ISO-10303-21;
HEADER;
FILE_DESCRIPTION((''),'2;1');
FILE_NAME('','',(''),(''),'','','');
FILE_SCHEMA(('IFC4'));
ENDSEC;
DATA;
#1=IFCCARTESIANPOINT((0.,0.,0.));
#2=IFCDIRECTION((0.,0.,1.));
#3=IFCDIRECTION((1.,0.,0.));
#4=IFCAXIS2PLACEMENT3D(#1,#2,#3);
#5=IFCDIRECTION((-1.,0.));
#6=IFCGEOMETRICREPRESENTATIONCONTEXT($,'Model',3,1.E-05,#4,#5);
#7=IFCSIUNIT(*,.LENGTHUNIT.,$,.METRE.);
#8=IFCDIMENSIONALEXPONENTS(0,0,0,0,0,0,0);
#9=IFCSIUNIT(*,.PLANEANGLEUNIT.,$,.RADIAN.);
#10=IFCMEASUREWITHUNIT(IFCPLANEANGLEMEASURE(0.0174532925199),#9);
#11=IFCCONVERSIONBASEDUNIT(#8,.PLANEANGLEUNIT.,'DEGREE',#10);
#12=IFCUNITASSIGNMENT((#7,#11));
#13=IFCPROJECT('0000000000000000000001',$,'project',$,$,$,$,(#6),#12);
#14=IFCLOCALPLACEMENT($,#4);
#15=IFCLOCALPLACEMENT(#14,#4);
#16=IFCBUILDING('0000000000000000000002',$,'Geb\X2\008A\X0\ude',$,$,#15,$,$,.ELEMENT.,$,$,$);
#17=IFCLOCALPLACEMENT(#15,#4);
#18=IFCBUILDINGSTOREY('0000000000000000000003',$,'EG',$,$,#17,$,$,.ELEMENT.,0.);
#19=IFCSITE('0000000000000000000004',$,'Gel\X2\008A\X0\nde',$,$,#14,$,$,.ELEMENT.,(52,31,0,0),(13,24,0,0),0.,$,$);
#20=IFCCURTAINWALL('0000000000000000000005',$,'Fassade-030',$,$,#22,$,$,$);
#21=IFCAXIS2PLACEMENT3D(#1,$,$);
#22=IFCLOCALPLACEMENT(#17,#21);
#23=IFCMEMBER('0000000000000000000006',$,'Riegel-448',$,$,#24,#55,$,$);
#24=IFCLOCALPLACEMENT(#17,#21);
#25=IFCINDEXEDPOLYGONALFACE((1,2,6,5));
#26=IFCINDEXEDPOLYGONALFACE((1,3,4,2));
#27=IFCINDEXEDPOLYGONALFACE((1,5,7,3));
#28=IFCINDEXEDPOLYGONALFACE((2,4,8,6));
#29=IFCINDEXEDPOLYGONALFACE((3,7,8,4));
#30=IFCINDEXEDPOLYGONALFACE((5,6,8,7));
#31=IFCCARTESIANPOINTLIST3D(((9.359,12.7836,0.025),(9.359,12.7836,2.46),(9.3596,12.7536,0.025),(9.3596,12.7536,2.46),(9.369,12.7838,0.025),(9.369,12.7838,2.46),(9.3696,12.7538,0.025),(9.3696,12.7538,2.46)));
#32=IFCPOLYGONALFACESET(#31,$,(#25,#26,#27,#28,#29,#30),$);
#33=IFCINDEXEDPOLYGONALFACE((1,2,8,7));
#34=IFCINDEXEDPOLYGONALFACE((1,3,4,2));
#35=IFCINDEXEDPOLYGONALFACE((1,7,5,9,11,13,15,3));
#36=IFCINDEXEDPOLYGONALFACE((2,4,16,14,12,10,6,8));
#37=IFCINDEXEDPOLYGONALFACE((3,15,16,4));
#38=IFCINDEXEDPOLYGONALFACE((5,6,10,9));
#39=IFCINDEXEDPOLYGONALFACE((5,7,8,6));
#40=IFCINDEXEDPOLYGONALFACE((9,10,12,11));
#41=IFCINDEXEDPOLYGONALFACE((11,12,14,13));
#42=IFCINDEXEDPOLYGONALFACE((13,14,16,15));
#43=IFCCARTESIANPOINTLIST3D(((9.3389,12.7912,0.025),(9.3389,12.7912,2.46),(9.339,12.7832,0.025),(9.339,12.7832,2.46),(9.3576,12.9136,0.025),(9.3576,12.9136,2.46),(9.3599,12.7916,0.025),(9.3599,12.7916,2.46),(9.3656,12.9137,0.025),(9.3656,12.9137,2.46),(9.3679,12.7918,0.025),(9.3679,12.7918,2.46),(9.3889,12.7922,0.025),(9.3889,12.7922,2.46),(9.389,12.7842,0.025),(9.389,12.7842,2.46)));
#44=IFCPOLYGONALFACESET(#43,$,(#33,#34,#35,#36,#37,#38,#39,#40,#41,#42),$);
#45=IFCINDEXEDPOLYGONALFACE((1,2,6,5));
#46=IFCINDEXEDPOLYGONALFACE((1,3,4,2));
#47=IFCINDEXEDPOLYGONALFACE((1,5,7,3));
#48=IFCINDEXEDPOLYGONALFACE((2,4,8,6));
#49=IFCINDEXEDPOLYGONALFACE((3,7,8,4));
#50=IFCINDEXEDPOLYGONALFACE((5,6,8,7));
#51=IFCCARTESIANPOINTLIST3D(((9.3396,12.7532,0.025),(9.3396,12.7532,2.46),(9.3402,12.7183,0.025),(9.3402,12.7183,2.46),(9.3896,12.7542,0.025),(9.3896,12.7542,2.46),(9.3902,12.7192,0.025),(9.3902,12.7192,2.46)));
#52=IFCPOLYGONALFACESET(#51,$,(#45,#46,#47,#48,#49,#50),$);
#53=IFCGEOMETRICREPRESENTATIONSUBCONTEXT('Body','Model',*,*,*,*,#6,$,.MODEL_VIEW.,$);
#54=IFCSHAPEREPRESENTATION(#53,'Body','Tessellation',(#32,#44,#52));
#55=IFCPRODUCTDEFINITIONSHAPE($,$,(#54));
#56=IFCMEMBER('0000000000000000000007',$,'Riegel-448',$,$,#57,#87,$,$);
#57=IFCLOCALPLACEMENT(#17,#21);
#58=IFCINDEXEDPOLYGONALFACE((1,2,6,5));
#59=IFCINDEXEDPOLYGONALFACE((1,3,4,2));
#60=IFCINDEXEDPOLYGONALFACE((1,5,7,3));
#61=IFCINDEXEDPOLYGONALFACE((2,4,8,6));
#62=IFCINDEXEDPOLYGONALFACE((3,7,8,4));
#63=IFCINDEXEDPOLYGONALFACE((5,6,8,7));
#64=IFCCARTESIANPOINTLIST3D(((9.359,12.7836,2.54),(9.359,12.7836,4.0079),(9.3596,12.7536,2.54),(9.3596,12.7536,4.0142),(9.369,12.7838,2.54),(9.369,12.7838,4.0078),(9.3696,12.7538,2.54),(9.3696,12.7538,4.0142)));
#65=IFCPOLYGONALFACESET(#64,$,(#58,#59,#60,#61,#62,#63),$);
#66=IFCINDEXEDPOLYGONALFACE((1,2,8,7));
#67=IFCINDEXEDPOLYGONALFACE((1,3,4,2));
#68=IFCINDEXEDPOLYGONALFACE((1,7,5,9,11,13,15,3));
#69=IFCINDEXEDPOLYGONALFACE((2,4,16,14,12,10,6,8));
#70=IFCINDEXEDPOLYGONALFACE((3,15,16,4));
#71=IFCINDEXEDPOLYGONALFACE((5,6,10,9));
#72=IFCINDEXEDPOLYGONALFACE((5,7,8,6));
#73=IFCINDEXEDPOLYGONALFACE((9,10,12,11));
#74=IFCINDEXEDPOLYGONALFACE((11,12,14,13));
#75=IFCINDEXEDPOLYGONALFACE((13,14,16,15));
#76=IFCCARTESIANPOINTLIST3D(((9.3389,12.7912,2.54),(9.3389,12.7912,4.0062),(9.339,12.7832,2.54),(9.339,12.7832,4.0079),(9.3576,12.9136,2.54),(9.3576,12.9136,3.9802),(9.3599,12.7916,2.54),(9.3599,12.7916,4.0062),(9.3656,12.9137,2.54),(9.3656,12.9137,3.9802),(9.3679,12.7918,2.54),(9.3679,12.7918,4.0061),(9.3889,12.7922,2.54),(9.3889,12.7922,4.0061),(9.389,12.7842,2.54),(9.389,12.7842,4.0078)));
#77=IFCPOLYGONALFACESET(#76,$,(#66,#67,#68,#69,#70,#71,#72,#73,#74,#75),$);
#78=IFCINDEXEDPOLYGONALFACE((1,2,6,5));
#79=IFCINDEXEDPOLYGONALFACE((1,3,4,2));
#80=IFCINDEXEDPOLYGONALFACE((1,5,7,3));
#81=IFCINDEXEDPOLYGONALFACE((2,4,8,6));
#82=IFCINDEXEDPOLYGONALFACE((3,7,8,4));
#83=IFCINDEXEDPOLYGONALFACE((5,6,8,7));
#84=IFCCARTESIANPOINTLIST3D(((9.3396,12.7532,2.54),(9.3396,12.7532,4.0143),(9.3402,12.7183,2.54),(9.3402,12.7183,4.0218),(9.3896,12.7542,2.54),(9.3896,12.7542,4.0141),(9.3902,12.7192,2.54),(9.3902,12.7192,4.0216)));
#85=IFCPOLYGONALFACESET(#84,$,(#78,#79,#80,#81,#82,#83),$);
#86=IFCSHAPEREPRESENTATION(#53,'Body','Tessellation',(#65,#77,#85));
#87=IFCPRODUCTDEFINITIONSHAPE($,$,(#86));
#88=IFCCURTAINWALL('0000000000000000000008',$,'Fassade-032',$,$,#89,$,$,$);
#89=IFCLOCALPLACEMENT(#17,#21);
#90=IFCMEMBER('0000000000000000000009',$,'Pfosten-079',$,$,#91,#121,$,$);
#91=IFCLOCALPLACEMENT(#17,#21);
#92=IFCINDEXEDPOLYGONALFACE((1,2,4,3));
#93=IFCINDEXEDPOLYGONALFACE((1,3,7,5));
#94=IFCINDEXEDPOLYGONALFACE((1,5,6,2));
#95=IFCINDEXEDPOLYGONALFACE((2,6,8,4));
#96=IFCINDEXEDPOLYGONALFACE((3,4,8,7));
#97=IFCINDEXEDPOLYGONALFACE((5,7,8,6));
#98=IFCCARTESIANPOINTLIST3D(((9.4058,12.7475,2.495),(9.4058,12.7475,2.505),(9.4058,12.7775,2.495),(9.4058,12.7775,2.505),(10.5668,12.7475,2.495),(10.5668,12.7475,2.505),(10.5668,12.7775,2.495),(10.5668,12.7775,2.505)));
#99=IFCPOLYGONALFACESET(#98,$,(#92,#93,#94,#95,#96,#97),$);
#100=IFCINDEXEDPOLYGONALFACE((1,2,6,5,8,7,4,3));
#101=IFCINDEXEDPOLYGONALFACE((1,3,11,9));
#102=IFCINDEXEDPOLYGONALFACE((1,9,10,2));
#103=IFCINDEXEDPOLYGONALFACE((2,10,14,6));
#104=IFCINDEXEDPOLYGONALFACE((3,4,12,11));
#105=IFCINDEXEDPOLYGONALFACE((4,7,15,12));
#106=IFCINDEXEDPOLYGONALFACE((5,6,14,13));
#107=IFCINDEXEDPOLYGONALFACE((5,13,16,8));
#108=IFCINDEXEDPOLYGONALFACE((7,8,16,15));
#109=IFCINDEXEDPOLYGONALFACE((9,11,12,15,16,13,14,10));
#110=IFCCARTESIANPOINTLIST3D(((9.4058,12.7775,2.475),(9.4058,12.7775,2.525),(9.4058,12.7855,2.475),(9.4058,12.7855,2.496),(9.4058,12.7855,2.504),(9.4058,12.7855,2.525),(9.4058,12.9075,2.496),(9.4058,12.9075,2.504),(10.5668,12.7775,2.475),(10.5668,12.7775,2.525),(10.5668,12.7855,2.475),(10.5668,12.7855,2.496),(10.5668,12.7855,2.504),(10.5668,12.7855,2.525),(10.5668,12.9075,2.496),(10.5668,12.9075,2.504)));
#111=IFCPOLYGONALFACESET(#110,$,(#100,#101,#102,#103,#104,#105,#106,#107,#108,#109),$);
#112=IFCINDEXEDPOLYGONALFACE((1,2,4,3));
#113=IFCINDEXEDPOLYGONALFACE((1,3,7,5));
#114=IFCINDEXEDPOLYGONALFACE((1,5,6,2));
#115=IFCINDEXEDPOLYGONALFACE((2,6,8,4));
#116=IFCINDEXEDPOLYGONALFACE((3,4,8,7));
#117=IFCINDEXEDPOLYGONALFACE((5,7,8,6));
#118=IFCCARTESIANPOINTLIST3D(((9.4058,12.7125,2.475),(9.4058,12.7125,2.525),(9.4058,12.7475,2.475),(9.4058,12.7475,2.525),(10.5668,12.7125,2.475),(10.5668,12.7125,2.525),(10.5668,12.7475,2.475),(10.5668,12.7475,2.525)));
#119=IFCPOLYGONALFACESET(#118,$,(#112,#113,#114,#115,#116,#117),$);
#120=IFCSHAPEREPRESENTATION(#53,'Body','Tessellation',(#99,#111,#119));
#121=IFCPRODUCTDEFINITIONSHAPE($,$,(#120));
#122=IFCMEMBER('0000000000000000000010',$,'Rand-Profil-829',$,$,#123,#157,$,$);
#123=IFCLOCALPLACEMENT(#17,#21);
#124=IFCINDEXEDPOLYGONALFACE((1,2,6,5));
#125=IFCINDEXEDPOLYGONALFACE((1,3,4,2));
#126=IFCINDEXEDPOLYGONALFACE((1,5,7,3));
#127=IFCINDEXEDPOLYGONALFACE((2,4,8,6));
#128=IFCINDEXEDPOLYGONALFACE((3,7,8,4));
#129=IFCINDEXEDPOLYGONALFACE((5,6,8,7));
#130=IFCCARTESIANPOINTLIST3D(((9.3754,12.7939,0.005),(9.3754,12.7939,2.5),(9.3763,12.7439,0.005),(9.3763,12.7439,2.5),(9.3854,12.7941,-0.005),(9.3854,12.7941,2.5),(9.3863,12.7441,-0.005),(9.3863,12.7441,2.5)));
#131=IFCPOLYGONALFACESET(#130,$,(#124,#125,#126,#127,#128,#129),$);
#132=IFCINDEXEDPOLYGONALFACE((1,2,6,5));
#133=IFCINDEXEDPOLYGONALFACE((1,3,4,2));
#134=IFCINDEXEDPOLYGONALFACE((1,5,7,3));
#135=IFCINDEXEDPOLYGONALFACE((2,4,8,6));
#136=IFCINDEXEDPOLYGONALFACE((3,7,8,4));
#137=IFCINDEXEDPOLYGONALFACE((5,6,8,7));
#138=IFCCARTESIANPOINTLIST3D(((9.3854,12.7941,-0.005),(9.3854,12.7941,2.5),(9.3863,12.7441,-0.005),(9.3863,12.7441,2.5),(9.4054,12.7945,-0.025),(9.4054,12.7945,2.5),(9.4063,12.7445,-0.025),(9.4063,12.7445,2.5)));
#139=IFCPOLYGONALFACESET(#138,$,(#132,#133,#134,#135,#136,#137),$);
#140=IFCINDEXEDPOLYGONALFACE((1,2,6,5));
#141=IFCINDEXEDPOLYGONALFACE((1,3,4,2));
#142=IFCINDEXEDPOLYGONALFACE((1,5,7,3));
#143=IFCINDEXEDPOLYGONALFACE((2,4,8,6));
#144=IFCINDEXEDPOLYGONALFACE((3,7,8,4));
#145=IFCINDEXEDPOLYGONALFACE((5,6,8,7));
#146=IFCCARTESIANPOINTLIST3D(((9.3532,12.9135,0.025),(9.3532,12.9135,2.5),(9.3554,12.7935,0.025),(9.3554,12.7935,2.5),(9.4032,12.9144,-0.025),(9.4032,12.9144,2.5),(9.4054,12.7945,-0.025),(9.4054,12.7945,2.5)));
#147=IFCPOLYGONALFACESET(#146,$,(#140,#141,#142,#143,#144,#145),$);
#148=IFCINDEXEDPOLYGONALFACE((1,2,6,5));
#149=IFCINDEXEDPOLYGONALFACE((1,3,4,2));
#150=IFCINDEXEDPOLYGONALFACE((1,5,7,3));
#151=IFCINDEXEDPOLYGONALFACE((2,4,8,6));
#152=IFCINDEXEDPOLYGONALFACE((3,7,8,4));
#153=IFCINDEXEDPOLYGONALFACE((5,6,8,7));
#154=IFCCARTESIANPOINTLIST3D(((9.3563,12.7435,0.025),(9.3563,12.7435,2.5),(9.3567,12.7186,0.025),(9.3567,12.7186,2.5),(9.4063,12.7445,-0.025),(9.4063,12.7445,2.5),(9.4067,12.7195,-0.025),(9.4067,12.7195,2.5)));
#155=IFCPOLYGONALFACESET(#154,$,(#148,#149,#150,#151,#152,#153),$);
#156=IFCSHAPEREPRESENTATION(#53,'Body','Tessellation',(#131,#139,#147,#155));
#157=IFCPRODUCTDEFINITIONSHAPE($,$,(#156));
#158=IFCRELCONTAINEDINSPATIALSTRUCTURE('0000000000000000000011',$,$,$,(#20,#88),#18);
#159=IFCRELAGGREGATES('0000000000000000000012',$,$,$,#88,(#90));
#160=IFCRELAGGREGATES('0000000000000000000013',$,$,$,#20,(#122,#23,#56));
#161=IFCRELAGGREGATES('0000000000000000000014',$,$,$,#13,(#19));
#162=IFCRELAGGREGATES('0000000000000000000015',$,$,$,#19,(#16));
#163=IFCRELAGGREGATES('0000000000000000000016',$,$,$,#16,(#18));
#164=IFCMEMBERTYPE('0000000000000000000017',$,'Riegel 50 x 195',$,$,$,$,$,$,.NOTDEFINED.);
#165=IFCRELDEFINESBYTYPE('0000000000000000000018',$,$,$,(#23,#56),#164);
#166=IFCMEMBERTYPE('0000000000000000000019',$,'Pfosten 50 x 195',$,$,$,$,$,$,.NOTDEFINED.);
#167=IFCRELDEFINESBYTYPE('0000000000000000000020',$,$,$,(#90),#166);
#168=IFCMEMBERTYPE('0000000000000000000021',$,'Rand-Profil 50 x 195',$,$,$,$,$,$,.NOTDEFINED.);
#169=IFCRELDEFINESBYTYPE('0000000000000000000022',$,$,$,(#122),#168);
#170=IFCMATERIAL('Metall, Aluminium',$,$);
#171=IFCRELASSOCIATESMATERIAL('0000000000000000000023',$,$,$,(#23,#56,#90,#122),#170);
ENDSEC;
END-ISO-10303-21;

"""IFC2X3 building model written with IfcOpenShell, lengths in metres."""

from ifc_helpers import new_model, entity, si_unit, converted_unit, direction, frame, origin_with_axes, place, context, subcontext, project, spatial, polyline, outline, extrude, clip, halfspace, material, type_object, element, aggregate, save


model = new_model("IFC2X3")

# Units and contexts
model_context = context("Model", 3, precision=1e-05, world=origin_with_axes(), true_north=direction((-1.0, 0.0)))
body_context = subcontext(model_context, "Body", "Model", "MODEL_VIEW")
ifc_project = project(units=[si_unit("LENGTHUNIT", "METRE"), converted_unit("PLANEANGLEUNIT", "DEGREE", entity("IfcPlaneAngleMeasure", 0.0174532925199), si_unit("PLANEANGLEUNIT", "RADIAN"), dimensions=[0, 0, 0, 0, 0, 0, 0])], contexts=[model_context])

# Site, building, storey
site_placement = place(None, origin_with_axes())
site = spatial("IfcSite", under=ifc_project, at=site_placement, Name="Gel\u008ande", CompositionType="ELEMENT", RefLatitude=(52, 31, 0, 0), RefLongitude=(13, 24, 0, 0), RefElevation=0.0)
building_placement = place(site_placement, origin_with_axes())
building = spatial("IfcBuilding", under=site, at=building_placement, Name="Geb\u008aude", CompositionType="ELEMENT")
storey_placement = place(building_placement, origin_with_axes())
storey = spatial("IfcBuildingStorey", under=building, at=storey_placement, Name="EG", CompositionType="ELEMENT", Elevation=0.0)

# Curtain wall, members
curtain_wall_1_placement = place(storey_placement, frame((8.7714, 12.7579, 0.0), z_axis=(0.0, 0.0, 1.0), x_axis=(1.0, 0.0, 0.0)))
curtain_wall_1 = element("IfcCurtainWall", 1, at=curtain_wall_1_placement, inside=storey, Name="Fassade-030")
ifc_material_1 = material(Name="Metall, Aluminium")
member_type_1 = type_object("IfcMemberType", Name="Riegel 50 x 195", PredefinedType="NOTDEFINED")
member_1_placement = place(curtain_wall_1_placement, frame((0.5929, 0.0108, 0.0), z_axis=(0.0, 0.0, 1.0), x_axis=(-0.999835, -0.018178, 0.0)))
member_1 = element("IfcMember", 2, at=member_1_placement, type_object=member_type_1, material=ifc_material_1, Name="Riegel-448", context=body_context, shape_type="SweptSolid", body=[
    extrude(outline(polyline([(-0.0053, 0.0149), (-0.0047, -0.0151), (0.0053, -0.0149), (0.0047, 0.0151), (-0.0053, 0.0149)])), frame((0.0, 0.0, 0.025), z_axis=(0.0, 0.0, 1.0), x_axis=(-0.999835, 0.018178, 0.0)), (0.0, 0.0, 1.0), 2.435),
    extrude(outline(polyline([(-0.0066, 0.1449), (-0.0044, 0.0229), (-0.0254, 0.0225), (-0.0253, 0.0145), (0.0247, 0.0155), (0.0246, 0.0235), (0.0036, 0.0231), (0.0014, 0.145), (-0.0066, 0.1449)])), frame((0.0, 0.0, 0.025), z_axis=(0.0, 0.0, 1.0), x_axis=(-0.999835, 0.018178, 0.0)), (0.0, 0.0, 1.0), 2.435),
    extrude(outline(polyline([(0.0259, -0.0495), (0.0253, -0.0145), (-0.0247, -0.0155), (-0.0241, -0.0504), (0.0259, -0.0495)])), frame((0.0, 0.0, 0.025), z_axis=(0.0, 0.0, 1.0), x_axis=(-0.999835, 0.018178, 0.0)), (0.0, 0.0, 1.0), 2.435),
])
member_2_placement = place(curtain_wall_1_placement, frame((0.5929, 0.0108, 2.5), z_axis=(0.0, 0.0, 1.0), x_axis=(-0.999835, -0.018178, 0.0)))
member_2 = element("IfcMember", 3, at=member_2_placement, type_object=member_type_1, material=ifc_material_1, Name="Riegel-448", context=body_context, shape_type="Clipping", body=[
    clip(extrude(outline(polyline([(0.0053, -0.0149), (0.0047, 0.0151), (-0.0053, 0.0149), (-0.0047, -0.0151), (0.0053, -0.0149)])), frame((0.0, 0.0, 0.04), z_axis=(0.0, 0.0, 1.0), x_axis=(-0.999835, 0.018178, 0.0)), (0.0, 0.0, 1.0), 1.4742), halfspace(frame((-0.0056, -0.3072, 1.4457), z_axis=(0.003779, 0.207877, -0.978148), x_axis=(0.0, -0.978155, -0.207879)), True)),
    clip(extrude(outline(polyline([(0.0247, 0.0155), (0.0246, 0.0235), (0.0036, 0.0231), (0.0014, 0.145), (-0.0066, 0.1449), (-0.0044, 0.0229), (-0.0254, 0.0225), (-0.0253, 0.0145), (0.0247, 0.0155)])), frame((0.0, 0.0, 0.04), z_axis=(0.0, 0.0, 1.0), x_axis=(-0.999835, 0.018178, 0.0)), (0.0, 0.0, 1.0), 1.4679), halfspace(frame((-0.0056, -0.3072, 1.4457), z_axis=(0.003779, 0.207877, -0.978148), x_axis=(0.0, -0.978155, -0.207879)), True)),
    clip(extrude(outline(polyline([(0.0259, -0.0495), (0.0253, -0.0145), (-0.0247, -0.0155), (-0.0241, -0.0504), (0.0259, -0.0495)])), frame((0.0, 0.0, 0.04), z_axis=(0.0, 0.0, 1.0), x_axis=(-0.999835, 0.018178, 0.0)), (0.0, 0.0, 1.0), 1.4818), halfspace(frame((-0.0056, -0.3072, 1.4457), z_axis=(0.003779, 0.207877, -0.978148), x_axis=(0.0, -0.978155, -0.207879)), True)),
])

# Curtain wall, member
curtain_wall_2_placement = place(storey_placement, frame((9.9738, 12.7625, 0.0), z_axis=(0.0, 0.0, 1.0), x_axis=(1.0, 0.0, 0.0)))
curtain_wall_2 = element("IfcCurtainWall", 4, at=curtain_wall_2_placement, inside=storey, Name="Fassade-032")
member_type_2 = type_object("IfcMemberType", Name="Pfosten 50 x 195", PredefinedType="NOTDEFINED")
member_3_placement = place(curtain_wall_2_placement, frame((-0.593, 0.0, 2.5), z_axis=(1.0, 0.0, 0.0), x_axis=(0.0, 0.0, 1.0)))
member_3 = element("IfcMember", 5, at=member_3_placement, type_object=member_type_2, material=ifc_material_1, Name="Pfosten-079", context=body_context, shape_type="SweptSolid", body=[
    extrude(outline(polyline([(-0.015, -0.005), (0.015, -0.005), (0.015, 0.005), (-0.015, 0.005), (-0.015, -0.005)])), frame((0.0, 0.0, 0.025), z_axis=(0.0, 0.0, 1.0), x_axis=(0.0, 1.0, 0.0)), (0.0, 0.0, 1.0), 1.161),
    extrude(outline(polyline([(-0.145, -0.004), (-0.023, -0.004), (-0.023, -0.025), (-0.015, -0.025), (-0.015, 0.025), (-0.023, 0.025), (-0.023, 0.004), (-0.145, 0.004), (-0.145, -0.004)])), frame((0.0, 0.0, 0.025), z_axis=(0.0, 0.0, 1.0), x_axis=(0.0, 1.0, 0.0)), (0.0, 0.0, 1.0), 1.161),
    extrude(outline(polyline([(0.05, 0.025), (0.015, 0.025), (0.015, -0.025), (0.05, -0.025), (0.05, 0.025)])), frame((0.0, 0.0, 0.025), z_axis=(0.0, 0.0, 1.0), x_axis=(0.0, 1.0, 0.0)), (0.0, 0.0, 1.0), 1.161),
])

# Member
member_type_3 = type_object("IfcMemberType", Name="Rand-Profil 50 x 195", PredefinedType="NOTDEFINED")
member_4_placement = place(curtain_wall_1_placement, frame((0.6094, 0.0111, 0.0), z_axis=(0.0, 0.0, 1.0), x_axis=(-0.999835, -0.018178, 0.0)))
member_4 = element("IfcMember", 6, at=member_4_placement, type_object=member_type_3, material=ifc_material_1, Name="Rand-Profil-829", context=body_context, shape_type="Clipping", body=[
    clip(extrude(outline(polyline([(-0.0055, 0.0249), (-0.0045, -0.0251), (0.0055, -0.0249), (0.0045, 0.0251), (-0.0055, 0.0249)])), frame((0.0, 0.0, -0.005), z_axis=(0.0, 0.0, 1.0), x_axis=(-0.999835, 0.018178, 0.0)), (0.0, 0.0, 1.0), 2.505), halfspace(frame((0.0, 0.0, 0.0), z_axis=(-0.707107, 0.0, 0.707107), x_axis=(-0.707107, 0.0, -0.707107)), True)),
    clip(extrude(outline(polyline([(0.0045, 0.0251), (0.0055, -0.0249), (0.0255, -0.0245), (0.0245, 0.0255), (0.0045, 0.0251)])), frame((0.0, 0.0, -0.025), z_axis=(0.0, 0.0, 1.0), x_axis=(-0.999835, 0.018178, 0.0)), (0.0, 0.0, 1.0), 2.525), halfspace(frame((0.0, 0.0, 0.0), z_axis=(-0.707107, 0.0, 0.707107), x_axis=(-0.707107, 0.0, -0.707107)), True)),
    clip(extrude(outline(polyline([(-0.0276, 0.1445), (-0.0255, 0.0245), (0.0245, 0.0255), (0.0224, 0.1454), (-0.0276, 0.1445)])), frame((0.0, 0.0, -0.025), z_axis=(0.0, 0.0, 1.0), x_axis=(-0.999835, 0.018178, 0.0)), (0.0, 0.0, 1.0), 2.525), halfspace(frame((0.0, 0.0, 0.0), z_axis=(-0.707107, 0.0, 0.707107), x_axis=(-0.707107, 0.0, -0.707107)), True)),
    clip(extrude(outline(polyline([(0.0259, -0.0495), (0.0255, -0.0245), (-0.0245, -0.0255), (-0.0241, -0.0504), (0.0259, -0.0495)])), frame((0.0, 0.0, -0.025), z_axis=(0.0, 0.0, 1.0), x_axis=(-0.999835, 0.018178, 0.0)), (0.0, 0.0, 1.0), 2.525), halfspace(frame((0.0, 0.0, 0.0), z_axis=(-0.707107, 0.0, 0.707107), x_axis=(-0.707107, 0.0, -0.707107)), True)),
])
aggregate(curtain_wall_2, [member_3])

aggregate(curtain_wall_1, [member_4, member_1, member_2])

save(model, "model.ifc")
